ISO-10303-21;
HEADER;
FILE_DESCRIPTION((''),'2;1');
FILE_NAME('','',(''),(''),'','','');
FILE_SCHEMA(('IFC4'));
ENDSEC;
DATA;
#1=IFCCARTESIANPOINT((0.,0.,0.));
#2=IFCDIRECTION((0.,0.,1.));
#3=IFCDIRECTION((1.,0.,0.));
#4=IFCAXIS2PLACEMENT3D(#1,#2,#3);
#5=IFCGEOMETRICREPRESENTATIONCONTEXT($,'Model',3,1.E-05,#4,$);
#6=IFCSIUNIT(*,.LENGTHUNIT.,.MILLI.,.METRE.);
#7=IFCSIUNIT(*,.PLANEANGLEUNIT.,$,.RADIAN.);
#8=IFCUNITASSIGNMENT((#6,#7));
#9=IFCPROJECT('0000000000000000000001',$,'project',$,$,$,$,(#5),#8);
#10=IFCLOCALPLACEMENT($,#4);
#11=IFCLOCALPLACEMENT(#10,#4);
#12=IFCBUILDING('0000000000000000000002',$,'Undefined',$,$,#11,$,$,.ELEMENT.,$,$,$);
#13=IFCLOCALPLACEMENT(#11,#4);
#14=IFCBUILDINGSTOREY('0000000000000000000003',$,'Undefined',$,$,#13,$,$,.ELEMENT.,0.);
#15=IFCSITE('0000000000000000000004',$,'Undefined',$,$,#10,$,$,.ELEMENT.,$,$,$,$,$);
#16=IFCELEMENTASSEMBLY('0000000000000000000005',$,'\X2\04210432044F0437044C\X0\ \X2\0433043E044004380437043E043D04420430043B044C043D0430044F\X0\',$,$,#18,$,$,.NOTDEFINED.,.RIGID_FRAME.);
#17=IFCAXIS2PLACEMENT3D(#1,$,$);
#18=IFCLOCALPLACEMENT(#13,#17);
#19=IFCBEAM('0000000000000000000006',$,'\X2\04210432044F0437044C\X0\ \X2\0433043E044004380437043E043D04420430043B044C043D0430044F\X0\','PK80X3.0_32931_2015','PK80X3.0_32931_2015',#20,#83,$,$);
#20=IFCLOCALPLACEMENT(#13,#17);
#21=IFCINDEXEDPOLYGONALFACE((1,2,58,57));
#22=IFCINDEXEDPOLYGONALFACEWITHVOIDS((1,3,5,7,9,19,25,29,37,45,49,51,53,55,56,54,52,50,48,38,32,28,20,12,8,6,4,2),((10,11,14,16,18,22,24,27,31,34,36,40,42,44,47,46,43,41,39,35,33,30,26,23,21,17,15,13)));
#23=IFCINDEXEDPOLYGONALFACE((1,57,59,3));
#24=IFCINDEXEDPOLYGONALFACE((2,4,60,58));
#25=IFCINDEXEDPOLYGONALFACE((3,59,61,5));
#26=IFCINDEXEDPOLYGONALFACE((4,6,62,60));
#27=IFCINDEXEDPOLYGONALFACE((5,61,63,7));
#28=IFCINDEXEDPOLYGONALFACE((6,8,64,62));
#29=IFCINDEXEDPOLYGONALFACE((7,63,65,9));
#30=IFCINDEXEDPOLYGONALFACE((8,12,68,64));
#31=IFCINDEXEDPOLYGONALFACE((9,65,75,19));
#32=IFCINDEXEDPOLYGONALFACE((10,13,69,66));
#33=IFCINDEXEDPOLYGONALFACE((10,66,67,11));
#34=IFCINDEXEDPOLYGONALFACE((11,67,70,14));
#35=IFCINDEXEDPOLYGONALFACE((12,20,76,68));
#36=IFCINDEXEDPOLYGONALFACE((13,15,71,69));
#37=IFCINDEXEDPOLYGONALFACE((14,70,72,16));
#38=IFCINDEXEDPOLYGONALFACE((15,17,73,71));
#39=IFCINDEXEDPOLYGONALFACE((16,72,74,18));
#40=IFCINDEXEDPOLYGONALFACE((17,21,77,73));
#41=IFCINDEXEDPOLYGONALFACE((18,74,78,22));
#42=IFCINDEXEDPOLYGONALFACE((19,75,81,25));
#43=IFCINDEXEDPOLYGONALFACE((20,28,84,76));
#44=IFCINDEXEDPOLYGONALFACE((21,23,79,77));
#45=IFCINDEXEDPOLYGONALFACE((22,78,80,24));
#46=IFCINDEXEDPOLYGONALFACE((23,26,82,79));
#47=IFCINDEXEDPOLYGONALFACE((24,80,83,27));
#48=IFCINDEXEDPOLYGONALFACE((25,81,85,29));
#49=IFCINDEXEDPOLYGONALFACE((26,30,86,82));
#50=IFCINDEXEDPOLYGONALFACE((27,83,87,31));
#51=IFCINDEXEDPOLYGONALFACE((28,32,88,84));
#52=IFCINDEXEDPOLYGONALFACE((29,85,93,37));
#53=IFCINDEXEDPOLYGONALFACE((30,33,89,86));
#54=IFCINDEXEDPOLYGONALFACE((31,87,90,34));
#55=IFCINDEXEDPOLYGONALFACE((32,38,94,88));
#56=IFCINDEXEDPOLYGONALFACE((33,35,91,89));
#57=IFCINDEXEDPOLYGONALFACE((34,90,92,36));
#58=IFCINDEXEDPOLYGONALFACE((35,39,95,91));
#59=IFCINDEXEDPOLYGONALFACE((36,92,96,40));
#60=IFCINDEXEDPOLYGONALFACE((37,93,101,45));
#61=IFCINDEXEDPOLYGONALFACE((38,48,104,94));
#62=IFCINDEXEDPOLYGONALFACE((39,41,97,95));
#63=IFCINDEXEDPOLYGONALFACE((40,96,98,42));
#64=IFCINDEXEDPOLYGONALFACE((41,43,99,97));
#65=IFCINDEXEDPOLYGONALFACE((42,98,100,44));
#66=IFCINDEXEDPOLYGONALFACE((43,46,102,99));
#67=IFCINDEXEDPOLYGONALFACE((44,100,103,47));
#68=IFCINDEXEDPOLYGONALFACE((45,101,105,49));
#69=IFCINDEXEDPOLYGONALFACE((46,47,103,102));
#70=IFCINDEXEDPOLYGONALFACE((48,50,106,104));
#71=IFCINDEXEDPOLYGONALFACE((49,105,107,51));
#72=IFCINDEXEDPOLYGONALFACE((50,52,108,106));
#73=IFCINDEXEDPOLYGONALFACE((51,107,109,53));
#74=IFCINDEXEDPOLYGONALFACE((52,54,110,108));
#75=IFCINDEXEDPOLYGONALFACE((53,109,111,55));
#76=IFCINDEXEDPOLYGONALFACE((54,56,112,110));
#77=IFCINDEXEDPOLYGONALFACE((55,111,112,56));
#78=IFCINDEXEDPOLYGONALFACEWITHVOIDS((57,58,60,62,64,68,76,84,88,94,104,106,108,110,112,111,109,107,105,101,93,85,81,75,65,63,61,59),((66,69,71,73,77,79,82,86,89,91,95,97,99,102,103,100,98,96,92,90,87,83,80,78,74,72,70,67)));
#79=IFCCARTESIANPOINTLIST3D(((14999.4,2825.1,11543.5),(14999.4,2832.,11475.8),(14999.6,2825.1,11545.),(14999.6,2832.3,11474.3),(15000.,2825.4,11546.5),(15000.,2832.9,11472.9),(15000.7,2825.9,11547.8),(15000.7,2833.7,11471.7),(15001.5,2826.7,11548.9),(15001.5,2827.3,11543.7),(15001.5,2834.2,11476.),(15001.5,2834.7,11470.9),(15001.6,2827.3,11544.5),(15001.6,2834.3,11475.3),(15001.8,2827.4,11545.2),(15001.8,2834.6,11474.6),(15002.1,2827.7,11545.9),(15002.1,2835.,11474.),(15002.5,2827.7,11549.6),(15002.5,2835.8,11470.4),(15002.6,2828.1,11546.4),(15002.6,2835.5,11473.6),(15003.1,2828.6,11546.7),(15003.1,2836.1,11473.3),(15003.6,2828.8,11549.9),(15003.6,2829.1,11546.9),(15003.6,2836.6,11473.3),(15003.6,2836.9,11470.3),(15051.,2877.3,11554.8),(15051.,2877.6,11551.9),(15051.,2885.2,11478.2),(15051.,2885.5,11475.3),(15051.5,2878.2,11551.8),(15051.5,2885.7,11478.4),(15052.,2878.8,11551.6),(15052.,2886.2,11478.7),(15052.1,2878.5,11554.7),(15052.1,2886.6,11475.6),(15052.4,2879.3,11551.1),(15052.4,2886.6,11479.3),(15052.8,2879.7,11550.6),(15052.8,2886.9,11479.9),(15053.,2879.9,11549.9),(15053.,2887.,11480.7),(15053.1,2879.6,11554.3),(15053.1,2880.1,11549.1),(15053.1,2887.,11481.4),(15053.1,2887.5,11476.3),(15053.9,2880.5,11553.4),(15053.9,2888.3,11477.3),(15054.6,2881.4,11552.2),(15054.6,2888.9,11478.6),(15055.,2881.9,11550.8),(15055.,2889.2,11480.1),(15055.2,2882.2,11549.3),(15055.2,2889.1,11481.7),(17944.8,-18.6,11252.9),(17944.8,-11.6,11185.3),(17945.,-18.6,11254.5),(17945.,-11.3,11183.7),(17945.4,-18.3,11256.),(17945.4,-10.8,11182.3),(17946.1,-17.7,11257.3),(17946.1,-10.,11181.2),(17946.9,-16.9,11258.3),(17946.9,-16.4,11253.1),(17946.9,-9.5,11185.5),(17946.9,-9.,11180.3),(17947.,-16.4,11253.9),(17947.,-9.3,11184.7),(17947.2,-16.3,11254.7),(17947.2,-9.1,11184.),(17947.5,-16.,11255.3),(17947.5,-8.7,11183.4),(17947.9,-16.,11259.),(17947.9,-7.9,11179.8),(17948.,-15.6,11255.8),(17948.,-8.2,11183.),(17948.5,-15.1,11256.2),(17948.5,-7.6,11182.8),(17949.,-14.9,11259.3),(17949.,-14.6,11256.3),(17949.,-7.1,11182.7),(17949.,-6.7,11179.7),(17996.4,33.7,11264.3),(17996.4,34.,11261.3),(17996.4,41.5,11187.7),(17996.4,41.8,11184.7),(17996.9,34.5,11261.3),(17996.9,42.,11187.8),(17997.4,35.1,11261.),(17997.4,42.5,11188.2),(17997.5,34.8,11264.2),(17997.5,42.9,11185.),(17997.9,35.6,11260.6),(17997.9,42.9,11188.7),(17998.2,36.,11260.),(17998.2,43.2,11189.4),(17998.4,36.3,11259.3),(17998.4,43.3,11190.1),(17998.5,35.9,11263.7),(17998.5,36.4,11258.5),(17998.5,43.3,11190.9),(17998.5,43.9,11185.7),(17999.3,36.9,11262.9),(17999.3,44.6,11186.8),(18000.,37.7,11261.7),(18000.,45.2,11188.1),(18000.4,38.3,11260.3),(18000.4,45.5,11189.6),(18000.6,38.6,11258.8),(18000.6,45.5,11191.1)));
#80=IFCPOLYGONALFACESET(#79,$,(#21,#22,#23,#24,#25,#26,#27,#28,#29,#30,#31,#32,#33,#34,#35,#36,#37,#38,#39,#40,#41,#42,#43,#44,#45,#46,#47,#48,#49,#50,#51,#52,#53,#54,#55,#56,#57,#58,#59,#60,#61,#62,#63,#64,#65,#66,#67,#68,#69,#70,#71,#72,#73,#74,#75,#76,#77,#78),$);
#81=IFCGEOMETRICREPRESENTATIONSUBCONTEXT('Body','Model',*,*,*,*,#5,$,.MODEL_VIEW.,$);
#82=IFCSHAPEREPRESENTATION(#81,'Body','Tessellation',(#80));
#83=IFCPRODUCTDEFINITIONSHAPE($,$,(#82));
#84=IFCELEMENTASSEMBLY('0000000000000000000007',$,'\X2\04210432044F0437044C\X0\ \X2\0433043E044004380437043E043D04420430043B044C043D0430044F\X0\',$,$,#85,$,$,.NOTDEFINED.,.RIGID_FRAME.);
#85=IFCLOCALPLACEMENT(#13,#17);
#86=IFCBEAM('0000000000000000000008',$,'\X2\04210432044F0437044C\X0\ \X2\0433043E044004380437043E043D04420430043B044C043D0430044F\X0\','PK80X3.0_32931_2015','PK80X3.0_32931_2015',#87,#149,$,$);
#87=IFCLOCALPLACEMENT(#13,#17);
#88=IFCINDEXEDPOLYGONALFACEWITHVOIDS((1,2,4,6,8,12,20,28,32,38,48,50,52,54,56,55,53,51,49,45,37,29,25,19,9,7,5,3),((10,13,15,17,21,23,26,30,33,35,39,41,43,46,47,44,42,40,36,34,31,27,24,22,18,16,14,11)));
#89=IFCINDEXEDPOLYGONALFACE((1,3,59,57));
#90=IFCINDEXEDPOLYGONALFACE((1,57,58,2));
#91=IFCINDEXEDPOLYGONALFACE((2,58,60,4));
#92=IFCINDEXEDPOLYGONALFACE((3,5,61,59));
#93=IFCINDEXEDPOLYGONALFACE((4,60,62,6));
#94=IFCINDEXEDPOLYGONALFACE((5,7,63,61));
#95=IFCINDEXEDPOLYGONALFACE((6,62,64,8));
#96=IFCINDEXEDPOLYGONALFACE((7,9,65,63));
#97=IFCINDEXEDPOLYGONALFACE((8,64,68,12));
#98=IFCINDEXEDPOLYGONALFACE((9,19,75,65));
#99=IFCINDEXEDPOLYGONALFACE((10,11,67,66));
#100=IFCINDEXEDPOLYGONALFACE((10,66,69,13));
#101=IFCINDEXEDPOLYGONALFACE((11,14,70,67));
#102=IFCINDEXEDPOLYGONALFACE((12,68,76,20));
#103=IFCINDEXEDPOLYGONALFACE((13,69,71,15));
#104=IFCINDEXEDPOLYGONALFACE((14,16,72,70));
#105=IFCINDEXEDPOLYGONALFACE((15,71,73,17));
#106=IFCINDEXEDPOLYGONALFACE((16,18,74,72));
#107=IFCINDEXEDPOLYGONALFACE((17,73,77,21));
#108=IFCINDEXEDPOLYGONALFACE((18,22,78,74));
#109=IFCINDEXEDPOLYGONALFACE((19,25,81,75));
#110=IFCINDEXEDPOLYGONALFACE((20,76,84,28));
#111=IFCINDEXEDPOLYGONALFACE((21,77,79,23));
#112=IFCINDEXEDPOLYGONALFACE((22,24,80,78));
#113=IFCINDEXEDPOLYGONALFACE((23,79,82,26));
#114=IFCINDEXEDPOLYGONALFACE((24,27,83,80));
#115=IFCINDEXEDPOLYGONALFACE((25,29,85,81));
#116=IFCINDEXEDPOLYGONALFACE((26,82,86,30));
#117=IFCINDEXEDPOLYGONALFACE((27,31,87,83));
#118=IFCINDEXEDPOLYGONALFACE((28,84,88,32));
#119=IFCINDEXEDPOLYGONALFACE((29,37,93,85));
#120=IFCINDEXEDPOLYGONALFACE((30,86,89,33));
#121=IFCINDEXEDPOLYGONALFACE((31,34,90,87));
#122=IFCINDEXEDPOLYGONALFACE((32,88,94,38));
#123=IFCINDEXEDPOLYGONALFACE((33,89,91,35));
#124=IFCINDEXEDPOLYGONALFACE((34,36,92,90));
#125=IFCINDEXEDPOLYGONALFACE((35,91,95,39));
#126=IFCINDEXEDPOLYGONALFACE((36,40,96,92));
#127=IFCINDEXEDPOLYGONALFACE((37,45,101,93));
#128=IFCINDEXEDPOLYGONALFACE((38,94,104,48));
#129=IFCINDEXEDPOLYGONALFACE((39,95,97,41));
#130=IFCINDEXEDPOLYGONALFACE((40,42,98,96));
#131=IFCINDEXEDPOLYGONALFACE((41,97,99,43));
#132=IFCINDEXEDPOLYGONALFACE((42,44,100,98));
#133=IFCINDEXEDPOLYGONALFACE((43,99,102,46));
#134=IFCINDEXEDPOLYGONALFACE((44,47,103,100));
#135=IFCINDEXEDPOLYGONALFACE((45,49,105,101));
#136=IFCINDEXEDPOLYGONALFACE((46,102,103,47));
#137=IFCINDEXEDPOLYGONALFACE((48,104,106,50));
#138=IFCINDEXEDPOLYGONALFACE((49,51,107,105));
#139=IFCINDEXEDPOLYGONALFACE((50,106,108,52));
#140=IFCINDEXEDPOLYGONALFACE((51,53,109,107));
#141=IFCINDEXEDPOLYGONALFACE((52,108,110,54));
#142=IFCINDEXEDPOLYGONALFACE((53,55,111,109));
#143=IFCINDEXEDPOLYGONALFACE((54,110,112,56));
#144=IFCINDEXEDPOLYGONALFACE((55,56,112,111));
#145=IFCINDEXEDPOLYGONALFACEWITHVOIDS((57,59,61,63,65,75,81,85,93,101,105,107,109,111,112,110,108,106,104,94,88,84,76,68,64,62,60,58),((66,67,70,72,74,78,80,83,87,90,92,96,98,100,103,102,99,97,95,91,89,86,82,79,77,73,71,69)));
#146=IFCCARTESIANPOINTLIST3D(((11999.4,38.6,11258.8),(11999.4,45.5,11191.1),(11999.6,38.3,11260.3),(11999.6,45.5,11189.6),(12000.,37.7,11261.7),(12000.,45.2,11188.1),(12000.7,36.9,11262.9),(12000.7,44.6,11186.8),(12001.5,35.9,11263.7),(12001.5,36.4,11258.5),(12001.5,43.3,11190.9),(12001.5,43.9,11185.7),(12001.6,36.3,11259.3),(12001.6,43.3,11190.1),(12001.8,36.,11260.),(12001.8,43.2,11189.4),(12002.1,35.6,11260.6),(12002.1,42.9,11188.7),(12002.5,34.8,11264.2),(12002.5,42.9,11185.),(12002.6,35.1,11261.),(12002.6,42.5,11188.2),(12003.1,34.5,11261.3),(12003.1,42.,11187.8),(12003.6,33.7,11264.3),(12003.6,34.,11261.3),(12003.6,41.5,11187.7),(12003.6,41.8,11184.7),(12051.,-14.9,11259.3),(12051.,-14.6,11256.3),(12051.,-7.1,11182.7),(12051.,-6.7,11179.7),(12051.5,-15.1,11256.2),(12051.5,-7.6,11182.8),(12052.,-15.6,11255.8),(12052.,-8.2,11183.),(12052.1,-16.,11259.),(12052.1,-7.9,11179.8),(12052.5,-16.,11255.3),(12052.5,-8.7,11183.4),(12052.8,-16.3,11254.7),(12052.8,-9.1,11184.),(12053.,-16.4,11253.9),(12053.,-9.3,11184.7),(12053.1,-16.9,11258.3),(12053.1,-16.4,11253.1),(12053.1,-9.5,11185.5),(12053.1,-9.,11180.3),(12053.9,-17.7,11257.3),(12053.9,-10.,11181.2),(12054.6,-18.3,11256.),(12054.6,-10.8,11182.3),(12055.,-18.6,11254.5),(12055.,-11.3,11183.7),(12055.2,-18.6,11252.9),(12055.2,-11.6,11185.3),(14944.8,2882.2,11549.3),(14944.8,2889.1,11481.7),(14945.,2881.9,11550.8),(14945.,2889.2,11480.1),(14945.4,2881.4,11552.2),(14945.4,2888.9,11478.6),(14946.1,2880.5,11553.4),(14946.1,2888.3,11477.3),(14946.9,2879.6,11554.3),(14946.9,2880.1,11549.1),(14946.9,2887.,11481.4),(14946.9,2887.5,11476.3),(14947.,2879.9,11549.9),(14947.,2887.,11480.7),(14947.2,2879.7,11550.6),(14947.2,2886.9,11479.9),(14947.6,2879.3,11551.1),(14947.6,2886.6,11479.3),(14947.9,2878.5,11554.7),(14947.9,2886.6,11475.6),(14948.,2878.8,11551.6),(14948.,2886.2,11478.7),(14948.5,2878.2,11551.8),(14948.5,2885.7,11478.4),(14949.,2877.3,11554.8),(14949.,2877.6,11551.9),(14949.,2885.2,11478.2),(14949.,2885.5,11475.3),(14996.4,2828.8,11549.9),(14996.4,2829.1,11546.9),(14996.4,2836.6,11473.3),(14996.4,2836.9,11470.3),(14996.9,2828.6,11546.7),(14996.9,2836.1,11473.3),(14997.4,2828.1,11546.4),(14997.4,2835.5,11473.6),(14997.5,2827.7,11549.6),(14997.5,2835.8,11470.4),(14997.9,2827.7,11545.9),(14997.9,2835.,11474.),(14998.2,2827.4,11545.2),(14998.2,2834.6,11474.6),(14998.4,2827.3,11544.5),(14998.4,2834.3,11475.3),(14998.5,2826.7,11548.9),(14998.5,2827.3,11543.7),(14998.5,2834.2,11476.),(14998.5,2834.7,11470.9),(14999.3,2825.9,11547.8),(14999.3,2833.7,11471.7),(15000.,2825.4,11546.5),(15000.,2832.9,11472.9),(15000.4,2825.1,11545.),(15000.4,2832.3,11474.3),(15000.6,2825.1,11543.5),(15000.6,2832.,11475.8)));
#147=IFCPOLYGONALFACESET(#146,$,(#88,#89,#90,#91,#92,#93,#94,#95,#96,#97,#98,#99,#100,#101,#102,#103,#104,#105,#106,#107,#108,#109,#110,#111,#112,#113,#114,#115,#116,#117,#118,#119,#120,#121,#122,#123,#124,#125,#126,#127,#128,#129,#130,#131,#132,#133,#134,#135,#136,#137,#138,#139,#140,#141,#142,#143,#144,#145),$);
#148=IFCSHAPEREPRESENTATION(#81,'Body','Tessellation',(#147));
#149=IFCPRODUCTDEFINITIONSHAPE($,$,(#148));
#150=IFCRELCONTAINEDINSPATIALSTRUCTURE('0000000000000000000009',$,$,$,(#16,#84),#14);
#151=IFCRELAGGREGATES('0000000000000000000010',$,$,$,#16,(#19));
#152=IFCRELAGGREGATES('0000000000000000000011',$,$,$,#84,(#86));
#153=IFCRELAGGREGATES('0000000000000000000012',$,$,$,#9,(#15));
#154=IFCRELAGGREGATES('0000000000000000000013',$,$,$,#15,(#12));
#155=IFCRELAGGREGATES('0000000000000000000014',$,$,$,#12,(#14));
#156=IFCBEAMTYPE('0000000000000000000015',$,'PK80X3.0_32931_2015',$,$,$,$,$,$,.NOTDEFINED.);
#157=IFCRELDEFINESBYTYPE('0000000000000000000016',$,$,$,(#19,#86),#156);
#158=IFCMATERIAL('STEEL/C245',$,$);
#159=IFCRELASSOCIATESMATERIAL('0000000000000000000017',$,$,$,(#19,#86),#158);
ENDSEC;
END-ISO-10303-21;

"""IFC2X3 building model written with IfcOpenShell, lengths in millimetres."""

from ifc_helpers import new_model, si_unit, frame, origin_with_axes, origin_2d_with_axis, place, context, subcontext, project, spatial, hollow_rectangle, extrude, material, type_object, element, aggregate, save


model = new_model("IFC2X3")

# Units and contexts
model_context = context("Model", 3, precision=1e-05, world=origin_with_axes())
body_context = subcontext(model_context, "Body", "Model", "MODEL_VIEW")
ifc_project = project(units=[si_unit("LENGTHUNIT", "METRE", prefix="MILLI"), si_unit("PLANEANGLEUNIT", "RADIAN")], contexts=[model_context])

# Site, building, storey
site_placement = place(None, origin_with_axes())
site = spatial("IfcSite", under=ifc_project, at=site_placement, Name="Undefined", CompositionType="ELEMENT")
building_placement = place(site_placement, origin_with_axes())
building = spatial("IfcBuilding", under=site, at=building_placement, Name="Undefined", CompositionType="ELEMENT")
storey_placement = place(building_placement, origin_with_axes())
storey = spatial("IfcBuildingStorey", under=building, at=storey_placement, Name="Undefined", CompositionType="ELEMENT", Elevation=0.0)

# Element assemblies, beams
ifc_material_1 = material(Name="STEEL/C245")
beam_type_1 = type_object("IfcBeamType", Name="PK80X3.0_32931_2015", PredefinedType="NOTDEFINED")
assembly_1_placement = place(storey_placement, origin_with_axes())
assembly_1 = element("IfcElementAssembly", 1, at=assembly_1_placement, inside=storey, Name="Связь горизонтальная", AssemblyPlace="NOTDEFINED", PredefinedType="RIGID_FRAME")
beam_1_placement = place(assembly_1_placement, frame((17972.7, 13.5, 11222.0), z_axis=(0.0, -0.101645, 0.994821), x_axis=(-0.717617, 0.69283, 0.070789)))
beam_1 = element("IfcBeam", 2, at=beam_1_placement, type_object=beam_type_1, material=ifc_material_1, Name="Связь горизонтальная", Description="PK80X3.0_32931_2015", ObjectType="PK80X3.0_32931_2015", context=body_context, shape_type="SweptSolid", body=[
    extrude(hollow_rectangle(XDim=80.0, YDim=80.0, WallThickness=3.0, InnerFilletRadius=3.0, OuterFilletRadius=6.0, at=origin_2d_with_axis()), frame((4104.4, 0.0, 0.0), z_axis=(-1.0, 0.0, 0.0), x_axis=(0.0, -1.0, 0.0)), (0.0, 0.0, 1.0), 4104.4),
])
aggregate(assembly_1, [beam_1])
assembly_2_placement = place(storey_placement, origin_with_axes())
assembly_2 = element("IfcElementAssembly", 3, at=assembly_2_placement, inside=storey, Name="Связь горизонтальная", AssemblyPlace="NOTDEFINED", PredefinedType="RIGID_FRAME")
beam_2_placement = place(assembly_2_placement, frame((12027.3, 13.5, 11222.0), z_axis=(0.0, -0.101645, 0.994821), x_axis=(0.717617, 0.69283, 0.070789)))
beam_2 = element("IfcBeam", 4, at=beam_2_placement, type_object=beam_type_1, material=ifc_material_1, Name="Связь горизонтальная", Description="PK80X3.0_32931_2015", ObjectType="PK80X3.0_32931_2015", context=body_context, shape_type="SweptSolid", body=[
    extrude(hollow_rectangle(XDim=80.0, YDim=80.0, WallThickness=3.0, InnerFilletRadius=3.0, OuterFilletRadius=6.0, at=origin_2d_with_axis()), frame((4104.4, 0.0, 0.0), z_axis=(-1.0, 0.0, 0.0), x_axis=(0.0, -1.0, 0.0)), (0.0, 0.0, 1.0), 4104.4),
])
aggregate(assembly_2, [beam_2])

save(model, "model.ifc")
